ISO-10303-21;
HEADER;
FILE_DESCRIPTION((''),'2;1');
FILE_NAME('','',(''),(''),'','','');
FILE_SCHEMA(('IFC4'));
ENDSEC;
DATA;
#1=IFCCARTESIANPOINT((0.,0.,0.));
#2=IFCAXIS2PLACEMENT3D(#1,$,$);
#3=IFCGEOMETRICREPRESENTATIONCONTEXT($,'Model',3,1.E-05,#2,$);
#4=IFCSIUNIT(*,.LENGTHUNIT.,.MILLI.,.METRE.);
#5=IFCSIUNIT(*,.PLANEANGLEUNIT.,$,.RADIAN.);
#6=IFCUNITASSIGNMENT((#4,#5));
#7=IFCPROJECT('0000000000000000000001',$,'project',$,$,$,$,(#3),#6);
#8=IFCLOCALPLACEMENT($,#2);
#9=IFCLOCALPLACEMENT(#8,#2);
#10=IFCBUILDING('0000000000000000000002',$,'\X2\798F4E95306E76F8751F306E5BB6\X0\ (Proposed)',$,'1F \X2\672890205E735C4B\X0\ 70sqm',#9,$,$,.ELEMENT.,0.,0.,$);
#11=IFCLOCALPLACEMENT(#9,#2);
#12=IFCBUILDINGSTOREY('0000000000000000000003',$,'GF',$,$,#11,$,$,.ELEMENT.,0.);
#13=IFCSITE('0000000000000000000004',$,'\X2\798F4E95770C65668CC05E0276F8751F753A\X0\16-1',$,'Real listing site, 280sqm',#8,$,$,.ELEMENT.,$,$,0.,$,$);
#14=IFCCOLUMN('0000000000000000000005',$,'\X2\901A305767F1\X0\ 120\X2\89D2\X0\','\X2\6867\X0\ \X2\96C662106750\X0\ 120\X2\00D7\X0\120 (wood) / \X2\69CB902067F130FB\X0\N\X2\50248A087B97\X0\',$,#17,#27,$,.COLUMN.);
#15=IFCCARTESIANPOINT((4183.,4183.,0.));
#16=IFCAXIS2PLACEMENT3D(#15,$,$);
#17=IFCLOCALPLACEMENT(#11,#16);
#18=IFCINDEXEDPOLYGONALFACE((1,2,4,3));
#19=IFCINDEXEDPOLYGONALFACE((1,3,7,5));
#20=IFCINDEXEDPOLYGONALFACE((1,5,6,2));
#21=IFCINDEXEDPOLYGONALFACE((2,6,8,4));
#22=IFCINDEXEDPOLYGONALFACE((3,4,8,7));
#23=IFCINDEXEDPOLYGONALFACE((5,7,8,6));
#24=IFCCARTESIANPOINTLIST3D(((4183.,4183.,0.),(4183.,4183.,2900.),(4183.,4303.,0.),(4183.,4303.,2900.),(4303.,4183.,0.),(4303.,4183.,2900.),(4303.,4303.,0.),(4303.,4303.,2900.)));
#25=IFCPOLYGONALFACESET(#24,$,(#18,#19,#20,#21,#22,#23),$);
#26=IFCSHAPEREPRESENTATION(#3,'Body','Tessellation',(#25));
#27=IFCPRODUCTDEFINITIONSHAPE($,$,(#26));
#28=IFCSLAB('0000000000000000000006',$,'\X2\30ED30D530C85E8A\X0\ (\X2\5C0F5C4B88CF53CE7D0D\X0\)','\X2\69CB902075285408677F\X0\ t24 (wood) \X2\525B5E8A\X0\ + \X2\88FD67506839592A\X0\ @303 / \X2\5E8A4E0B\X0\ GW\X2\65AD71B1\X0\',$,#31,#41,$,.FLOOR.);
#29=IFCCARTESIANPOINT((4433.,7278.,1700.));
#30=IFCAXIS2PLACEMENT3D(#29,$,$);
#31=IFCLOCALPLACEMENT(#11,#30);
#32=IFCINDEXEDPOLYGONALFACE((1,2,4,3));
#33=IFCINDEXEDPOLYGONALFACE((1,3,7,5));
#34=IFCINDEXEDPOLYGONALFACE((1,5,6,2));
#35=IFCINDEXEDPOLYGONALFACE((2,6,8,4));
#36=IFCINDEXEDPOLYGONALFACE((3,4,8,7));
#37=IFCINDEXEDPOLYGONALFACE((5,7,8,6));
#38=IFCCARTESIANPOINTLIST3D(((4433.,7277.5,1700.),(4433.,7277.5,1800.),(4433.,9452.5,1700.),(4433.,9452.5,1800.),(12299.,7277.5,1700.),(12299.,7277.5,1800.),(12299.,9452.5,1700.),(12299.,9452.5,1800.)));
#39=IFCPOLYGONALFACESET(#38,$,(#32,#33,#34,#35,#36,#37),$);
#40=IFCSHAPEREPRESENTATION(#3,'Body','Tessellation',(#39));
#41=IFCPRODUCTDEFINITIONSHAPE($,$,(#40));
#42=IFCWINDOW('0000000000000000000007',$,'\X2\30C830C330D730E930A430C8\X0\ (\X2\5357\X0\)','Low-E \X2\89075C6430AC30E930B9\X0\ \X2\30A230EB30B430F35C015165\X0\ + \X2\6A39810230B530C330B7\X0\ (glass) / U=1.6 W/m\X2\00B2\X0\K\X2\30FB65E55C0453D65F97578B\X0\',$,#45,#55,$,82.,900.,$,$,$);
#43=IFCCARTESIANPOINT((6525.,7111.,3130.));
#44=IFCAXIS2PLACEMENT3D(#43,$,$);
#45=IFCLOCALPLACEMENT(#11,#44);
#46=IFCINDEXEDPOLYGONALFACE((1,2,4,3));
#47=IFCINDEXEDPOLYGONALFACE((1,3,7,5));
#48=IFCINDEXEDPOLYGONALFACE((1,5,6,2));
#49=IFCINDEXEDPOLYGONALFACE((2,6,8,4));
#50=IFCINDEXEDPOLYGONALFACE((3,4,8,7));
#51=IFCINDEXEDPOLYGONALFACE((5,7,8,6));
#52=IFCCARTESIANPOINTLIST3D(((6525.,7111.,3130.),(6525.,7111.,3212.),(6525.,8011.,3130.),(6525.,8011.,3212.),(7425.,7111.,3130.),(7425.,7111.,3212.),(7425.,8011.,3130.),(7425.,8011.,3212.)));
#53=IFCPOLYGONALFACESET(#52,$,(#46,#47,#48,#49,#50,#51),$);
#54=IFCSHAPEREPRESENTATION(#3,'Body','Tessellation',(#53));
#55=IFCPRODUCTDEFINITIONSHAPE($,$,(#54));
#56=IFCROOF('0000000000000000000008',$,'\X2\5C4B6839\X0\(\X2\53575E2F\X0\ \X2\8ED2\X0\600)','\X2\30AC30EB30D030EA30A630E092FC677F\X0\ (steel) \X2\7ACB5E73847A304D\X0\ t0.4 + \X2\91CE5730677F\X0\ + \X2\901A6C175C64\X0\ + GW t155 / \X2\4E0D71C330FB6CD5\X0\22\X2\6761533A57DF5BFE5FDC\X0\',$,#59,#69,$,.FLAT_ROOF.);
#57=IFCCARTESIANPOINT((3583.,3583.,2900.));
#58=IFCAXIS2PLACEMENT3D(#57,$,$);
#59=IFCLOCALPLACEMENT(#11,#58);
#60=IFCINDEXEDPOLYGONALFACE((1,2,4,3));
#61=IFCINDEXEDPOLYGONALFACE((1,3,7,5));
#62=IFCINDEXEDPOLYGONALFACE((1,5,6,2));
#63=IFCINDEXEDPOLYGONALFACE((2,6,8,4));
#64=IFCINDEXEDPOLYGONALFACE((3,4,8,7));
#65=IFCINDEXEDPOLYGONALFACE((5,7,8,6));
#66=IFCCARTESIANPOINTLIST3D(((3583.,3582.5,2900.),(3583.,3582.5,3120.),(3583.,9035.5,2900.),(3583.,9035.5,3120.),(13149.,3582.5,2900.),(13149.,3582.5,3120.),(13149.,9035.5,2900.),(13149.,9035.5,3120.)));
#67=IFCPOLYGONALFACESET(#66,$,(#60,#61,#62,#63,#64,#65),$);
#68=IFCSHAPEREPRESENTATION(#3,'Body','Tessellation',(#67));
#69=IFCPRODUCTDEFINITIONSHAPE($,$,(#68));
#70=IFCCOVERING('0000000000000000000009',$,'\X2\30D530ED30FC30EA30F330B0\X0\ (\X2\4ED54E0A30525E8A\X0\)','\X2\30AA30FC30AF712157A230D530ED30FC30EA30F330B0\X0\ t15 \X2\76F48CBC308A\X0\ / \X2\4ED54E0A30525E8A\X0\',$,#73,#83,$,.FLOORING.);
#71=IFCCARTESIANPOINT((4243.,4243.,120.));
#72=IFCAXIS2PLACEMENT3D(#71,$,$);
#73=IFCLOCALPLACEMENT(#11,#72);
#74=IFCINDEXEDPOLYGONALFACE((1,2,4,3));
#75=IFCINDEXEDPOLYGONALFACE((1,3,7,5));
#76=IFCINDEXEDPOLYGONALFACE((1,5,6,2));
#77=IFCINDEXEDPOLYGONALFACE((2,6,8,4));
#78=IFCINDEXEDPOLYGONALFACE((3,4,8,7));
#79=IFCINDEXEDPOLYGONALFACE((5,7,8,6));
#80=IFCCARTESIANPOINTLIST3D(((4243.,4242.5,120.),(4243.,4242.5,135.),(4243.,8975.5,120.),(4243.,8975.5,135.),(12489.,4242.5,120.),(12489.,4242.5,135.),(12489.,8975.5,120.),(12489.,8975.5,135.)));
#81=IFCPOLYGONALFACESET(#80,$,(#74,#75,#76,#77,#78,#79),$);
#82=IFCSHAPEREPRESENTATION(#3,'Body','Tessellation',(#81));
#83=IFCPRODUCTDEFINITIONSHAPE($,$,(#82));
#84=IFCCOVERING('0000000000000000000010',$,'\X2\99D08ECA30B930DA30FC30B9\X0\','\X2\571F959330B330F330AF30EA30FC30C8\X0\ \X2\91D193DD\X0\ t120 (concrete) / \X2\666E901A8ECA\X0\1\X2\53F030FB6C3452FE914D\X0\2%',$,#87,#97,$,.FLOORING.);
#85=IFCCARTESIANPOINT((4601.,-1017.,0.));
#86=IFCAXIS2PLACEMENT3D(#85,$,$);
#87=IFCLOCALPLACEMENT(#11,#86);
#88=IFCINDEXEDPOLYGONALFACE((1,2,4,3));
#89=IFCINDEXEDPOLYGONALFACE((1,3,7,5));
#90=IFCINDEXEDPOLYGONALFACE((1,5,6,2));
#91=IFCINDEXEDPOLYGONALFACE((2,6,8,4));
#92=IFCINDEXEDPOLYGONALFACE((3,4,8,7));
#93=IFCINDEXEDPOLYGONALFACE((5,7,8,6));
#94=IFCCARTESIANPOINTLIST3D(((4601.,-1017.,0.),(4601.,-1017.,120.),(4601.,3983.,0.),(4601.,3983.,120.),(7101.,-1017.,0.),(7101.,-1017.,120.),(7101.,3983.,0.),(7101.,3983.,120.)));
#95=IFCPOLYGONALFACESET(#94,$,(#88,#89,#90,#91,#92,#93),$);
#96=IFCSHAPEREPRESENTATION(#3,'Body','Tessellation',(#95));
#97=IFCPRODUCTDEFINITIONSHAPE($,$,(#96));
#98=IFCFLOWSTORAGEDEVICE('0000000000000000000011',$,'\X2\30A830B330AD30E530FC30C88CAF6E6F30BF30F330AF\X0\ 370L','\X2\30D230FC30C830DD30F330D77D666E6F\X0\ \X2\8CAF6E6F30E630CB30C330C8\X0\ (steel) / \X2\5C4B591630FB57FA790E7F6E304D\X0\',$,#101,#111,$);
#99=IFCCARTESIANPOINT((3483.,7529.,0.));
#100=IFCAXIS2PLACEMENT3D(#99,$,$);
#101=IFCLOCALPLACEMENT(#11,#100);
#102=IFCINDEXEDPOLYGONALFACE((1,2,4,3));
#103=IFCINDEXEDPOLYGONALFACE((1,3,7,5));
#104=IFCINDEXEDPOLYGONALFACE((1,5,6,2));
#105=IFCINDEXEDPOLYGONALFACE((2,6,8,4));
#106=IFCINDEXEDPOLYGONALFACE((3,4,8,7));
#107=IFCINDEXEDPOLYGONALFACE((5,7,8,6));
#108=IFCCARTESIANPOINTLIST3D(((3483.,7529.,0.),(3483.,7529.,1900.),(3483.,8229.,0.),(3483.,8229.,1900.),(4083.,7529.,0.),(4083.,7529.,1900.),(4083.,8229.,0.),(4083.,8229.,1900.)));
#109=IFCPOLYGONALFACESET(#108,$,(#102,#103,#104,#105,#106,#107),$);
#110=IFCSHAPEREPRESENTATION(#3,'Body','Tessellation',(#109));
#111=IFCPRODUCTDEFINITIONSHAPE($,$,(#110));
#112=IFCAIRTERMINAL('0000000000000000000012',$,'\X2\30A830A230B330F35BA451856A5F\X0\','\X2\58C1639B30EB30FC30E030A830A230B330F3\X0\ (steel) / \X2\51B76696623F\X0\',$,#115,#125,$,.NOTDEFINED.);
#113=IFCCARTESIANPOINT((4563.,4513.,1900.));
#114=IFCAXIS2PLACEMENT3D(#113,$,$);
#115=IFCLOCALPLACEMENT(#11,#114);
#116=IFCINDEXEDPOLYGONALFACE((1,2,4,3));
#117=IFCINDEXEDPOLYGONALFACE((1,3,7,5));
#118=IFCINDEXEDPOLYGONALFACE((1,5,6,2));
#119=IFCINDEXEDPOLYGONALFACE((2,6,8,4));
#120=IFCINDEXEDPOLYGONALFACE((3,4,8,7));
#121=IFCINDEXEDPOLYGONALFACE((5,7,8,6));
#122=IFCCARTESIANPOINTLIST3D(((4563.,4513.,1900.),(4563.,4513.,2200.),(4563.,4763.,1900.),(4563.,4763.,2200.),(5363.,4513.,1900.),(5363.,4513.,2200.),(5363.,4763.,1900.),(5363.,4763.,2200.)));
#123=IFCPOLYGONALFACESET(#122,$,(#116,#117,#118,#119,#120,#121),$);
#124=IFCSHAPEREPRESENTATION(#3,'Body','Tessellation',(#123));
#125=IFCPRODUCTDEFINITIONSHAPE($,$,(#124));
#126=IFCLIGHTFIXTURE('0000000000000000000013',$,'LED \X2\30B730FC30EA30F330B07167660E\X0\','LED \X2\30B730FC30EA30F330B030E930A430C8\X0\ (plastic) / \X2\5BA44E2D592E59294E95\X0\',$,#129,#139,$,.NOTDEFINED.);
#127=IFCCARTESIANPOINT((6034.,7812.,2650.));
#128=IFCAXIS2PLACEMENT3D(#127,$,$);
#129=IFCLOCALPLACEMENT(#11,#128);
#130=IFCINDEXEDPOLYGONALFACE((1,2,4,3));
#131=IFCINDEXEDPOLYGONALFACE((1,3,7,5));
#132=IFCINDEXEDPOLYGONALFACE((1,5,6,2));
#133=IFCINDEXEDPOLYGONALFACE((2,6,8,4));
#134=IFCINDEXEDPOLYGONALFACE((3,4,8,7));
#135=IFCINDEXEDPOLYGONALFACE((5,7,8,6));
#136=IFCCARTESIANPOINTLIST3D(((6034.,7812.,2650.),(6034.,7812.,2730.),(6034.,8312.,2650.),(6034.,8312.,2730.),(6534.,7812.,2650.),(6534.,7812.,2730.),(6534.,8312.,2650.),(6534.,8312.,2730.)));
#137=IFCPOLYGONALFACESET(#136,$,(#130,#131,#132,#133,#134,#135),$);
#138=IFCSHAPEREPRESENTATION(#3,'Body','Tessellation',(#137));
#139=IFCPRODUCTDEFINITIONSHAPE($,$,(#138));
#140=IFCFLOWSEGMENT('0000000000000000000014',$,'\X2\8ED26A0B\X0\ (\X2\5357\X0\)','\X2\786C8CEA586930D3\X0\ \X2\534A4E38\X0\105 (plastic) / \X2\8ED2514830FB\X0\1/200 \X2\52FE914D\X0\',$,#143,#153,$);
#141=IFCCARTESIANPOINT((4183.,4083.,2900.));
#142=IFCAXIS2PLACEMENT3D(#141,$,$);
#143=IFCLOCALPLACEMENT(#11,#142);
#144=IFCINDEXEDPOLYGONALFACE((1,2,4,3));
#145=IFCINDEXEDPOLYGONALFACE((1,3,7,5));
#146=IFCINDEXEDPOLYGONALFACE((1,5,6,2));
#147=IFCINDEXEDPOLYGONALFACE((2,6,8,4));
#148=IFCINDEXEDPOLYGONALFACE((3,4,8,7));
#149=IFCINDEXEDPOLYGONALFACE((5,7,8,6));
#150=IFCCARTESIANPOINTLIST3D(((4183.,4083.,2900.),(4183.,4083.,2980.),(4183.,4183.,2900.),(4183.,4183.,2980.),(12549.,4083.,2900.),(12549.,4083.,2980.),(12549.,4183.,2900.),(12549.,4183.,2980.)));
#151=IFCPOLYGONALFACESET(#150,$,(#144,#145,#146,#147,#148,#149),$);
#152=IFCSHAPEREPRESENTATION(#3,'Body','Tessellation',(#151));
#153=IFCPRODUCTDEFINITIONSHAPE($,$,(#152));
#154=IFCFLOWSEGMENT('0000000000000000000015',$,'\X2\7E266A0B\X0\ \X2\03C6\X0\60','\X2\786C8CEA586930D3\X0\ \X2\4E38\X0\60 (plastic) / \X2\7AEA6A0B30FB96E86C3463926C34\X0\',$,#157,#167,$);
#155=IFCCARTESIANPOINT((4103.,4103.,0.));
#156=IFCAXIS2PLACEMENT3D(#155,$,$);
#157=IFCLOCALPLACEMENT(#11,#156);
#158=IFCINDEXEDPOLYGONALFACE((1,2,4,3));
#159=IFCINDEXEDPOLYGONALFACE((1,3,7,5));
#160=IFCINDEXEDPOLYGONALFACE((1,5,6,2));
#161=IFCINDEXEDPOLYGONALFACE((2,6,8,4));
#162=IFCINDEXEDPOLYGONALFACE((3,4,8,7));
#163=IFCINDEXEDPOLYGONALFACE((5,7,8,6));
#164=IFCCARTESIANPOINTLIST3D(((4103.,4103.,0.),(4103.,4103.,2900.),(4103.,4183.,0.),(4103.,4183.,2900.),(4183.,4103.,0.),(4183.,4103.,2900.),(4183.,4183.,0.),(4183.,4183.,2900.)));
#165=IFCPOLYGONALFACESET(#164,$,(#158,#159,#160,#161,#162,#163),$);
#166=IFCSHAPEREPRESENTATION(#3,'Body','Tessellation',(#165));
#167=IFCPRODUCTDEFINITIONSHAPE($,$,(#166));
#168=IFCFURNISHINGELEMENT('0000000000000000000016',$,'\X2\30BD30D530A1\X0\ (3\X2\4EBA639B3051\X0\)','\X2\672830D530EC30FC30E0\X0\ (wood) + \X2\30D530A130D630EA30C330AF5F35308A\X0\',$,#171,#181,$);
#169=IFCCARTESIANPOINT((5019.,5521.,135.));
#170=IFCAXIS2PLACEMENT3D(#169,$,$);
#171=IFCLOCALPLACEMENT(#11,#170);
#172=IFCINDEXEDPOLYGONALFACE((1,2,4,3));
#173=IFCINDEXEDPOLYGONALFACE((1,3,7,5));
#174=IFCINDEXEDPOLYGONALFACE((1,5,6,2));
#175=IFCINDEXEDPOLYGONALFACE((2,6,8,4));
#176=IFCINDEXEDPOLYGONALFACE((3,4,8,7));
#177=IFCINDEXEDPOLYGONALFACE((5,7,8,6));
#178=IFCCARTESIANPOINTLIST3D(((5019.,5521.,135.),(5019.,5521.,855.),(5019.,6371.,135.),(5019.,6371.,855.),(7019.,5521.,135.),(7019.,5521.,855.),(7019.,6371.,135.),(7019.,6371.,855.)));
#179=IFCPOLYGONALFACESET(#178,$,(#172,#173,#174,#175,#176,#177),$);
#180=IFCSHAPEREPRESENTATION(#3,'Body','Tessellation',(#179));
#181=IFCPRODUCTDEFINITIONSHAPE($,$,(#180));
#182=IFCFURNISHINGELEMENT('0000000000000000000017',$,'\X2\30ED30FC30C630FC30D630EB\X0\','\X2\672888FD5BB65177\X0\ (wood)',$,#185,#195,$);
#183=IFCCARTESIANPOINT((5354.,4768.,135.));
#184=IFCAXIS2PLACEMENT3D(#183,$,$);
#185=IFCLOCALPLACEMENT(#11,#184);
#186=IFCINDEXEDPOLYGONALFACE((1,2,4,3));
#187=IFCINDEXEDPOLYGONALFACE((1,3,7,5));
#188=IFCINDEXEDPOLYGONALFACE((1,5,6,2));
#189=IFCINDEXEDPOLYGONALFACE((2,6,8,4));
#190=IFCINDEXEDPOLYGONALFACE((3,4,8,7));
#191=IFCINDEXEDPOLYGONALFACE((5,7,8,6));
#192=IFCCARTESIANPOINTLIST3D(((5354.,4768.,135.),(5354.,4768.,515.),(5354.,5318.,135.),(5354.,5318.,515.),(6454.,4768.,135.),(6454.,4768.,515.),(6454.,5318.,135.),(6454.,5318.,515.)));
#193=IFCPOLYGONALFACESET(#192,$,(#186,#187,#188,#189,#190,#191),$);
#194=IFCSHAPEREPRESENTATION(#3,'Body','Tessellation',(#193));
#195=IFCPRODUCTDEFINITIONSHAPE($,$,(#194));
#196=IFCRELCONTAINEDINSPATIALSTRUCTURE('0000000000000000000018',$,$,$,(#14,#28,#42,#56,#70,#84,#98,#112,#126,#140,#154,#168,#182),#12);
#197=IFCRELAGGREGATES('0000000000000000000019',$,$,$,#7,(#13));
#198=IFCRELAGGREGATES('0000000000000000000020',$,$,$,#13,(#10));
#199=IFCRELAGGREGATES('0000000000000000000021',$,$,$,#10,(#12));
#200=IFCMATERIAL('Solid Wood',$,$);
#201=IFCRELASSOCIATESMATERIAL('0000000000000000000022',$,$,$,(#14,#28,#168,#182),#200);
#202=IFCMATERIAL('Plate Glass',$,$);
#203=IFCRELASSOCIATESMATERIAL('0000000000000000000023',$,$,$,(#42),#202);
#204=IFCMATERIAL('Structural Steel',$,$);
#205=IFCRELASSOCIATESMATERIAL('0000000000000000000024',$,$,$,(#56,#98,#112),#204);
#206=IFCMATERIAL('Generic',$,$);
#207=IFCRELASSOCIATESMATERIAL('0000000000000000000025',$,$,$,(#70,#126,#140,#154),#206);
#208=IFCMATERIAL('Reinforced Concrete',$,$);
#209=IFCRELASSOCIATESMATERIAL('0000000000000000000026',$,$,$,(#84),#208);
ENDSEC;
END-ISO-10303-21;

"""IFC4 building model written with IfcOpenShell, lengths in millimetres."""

from ifc_helpers import new_model, si_unit, frame, frame_2d, origin, place, context, project, spatial, rectangle, extrude, material, element, save


model = new_model("IFC4")

# Units and contexts
model_context = context("Model", 3, precision=1e-05, world=origin())
ifc_project = project(units=[si_unit("LENGTHUNIT", "METRE", prefix="MILLI"), si_unit("PLANEANGLEUNIT", "RADIAN")], contexts=[model_context])

# Site, building, storey
site_placement = place(None, origin())
site = spatial("IfcSite", under=ifc_project, at=site_placement, Name="福井県敦賀市相生町16-1", ObjectType="Real listing site, 280sqm", CompositionType="ELEMENT", RefElevation=0.0)
building_placement = place(site_placement, origin())
building = spatial("IfcBuilding", under=site, at=building_placement, Name="福井の相生の家 (Proposed)", ObjectType="1F 木造平屋 70sqm", CompositionType="ELEMENT", ElevationOfRefHeight=0.0, ElevationOfTerrain=0.0)
storey_placement = place(building_placement, origin())
storey = spatial("IfcBuildingStorey", under=building, at=storey_placement, Name="GF", CompositionType="ELEMENT", Elevation=0.0)

# Column
ifc_material_1 = material(Name="Solid Wood")
column_1_placement = place(storey_placement, frame((4183.0, 4183.0, 0.0)))
element("IfcColumn", 1, at=column_1_placement, inside=storey, material=ifc_material_1, Name="通し柱 120角", Description="桧 集成材 120×120 (wood) / 構造柱・N値計算", PredefinedType="COLUMN", context=model_context, shape_type="SweptSolid", body=[
    extrude(rectangle(XDim=120.0, YDim=120.0, at=frame_2d((60.0, 60.0))), frame((4183.0, 4183.0, 0.0)), (0.0, 0.0, 1.0), 2900.0),
])

# Slab
ifc_material_2 = material(Name="Reinforced Concrete")
slab_1_placement = place(storey_placement, frame((4433.0, 7278.0, 1700.0)))
element("IfcSlab", 2, at=slab_1_placement, inside=storey, material=ifc_material_1, Name="ロフト床 (小屋裏収納)", Description="構造用合板 t24 (wood) 剛床 + 製材根太 @303 / 床下 GW断熱", PredefinedType="FLOOR", context=model_context, shape_type="SweptSolid", body=[
    extrude(rectangle(XDim=7866.0, YDim=2175.0, at=frame_2d((3933.0, 1087.0))), frame((4433.0, 7278.0, 1700.0)), (0.0, 0.0, 1.0), 100.0),
])

# Shared definitions
ifc_material_3 = material(Name="Plate Glass")

# Window
window_1_placement = place(storey_placement, frame((6525.0, 7111.0, 3130.0)))
element("IfcWindow", 3, at=window_1_placement, inside=storey, material=ifc_material_3, Name="トップライト (南)", Description="Low-E 複層ガラス アルゴン封入 + 樹脂サッシ (glass) / U=1.6 W/m²K・日射取得型", OverallHeight=82.0, OverallWidth=900.0, context=model_context, shape_type="SweptSolid", body=[
    extrude(rectangle(XDim=900.0, YDim=900.0, at=frame_2d((450.0, 450.0))), frame((6525.0, 7111.0, 3130.0)), (0.0, 0.0, 1.0), 82.0),
])

# Roof
ifc_material_4 = material(Name="Structural Steel")
roof_placement = place(storey_placement, frame((3583.0, 3583.0, 2900.0)))
element("IfcRoof", 4, at=roof_placement, inside=storey, material=ifc_material_4, Name="屋根(南帯 軒600)", Description="ガルバリウム鋼板 (steel) 立平葺き t0.4 + 野地板 + 通気層 + GW t155 / 不燃・法22条区域対応", PredefinedType="FLAT_ROOF", context=model_context, shape_type="SweptSolid", body=[
    extrude(rectangle(XDim=9566.0, YDim=5453.0, at=frame_2d((4783.0, 2726.0))), frame((3583.0, 3583.0, 2900.0)), (0.0, 0.0, 1.0), 220.0),
])

# Coverings
ifc_material_5 = material(Name="Generic")
covering_1_placement = place(storey_placement, frame((4243.0, 4243.0, 120.0)))
element("IfcCovering", 5, at=covering_1_placement, inside=storey, material=ifc_material_5, Name="フローリング (仕上げ床)", Description="オーク無垢フローリング t15 直貼り / 仕上げ床", PredefinedType="FLOORING", context=model_context, shape_type="SweptSolid", body=[
    extrude(rectangle(XDim=8246.0, YDim=4733.0, at=frame_2d((4123.0, 2366.0))), frame((4243.0, 4243.0, 120.0)), (0.0, 0.0, 1.0), 15.0),
])
covering_2_placement = place(storey_placement, frame((4601.0, -1017.0, 0.0)))
element("IfcCovering", 6, at=covering_2_placement, inside=storey, material=ifc_material_2, Name="駐車スペース", Description="土間コンクリート 金鏝 t120 (concrete) / 普通車1台・水勾配2%", PredefinedType="FLOORING", context=model_context, shape_type="SweptSolid", body=[
    extrude(rectangle(XDim=2500.0, YDim=5000.0, at=frame_2d((1250.0, 2500.0))), frame((4601.0, -1017.0, 0.0)), (0.0, 0.0, 1.0), 120.0),
])

# Flow storage device
flow_storage_device_placement = place(storey_placement, frame((3483.0, 7529.0, 0.0)))
element("IfcFlowStorageDevice", 7, at=flow_storage_device_placement, inside=storey, material=ifc_material_4, Name="エコキュート貯湯タンク 370L", Description="ヒートポンプ給湯 貯湯ユニット (steel) / 屋外・基礎置き", context=model_context, shape_type="SweptSolid", body=[
    extrude(rectangle(XDim=600.0, YDim=700.0, at=frame_2d((300.0, 350.0))), frame((3483.0, 7529.0, 0.0)), (0.0, 0.0, 1.0), 1900.0),
])

# Air terminal
air_terminal_placement = place(storey_placement, frame((4563.0, 4513.0, 1900.0)))
element("IfcAirTerminal", 8, at=air_terminal_placement, inside=storey, material=ifc_material_4, Name="エアコン室内機", Description="壁掛ルームエアコン (steel) / 冷暖房", PredefinedType="NOTDEFINED", context=model_context, shape_type="SweptSolid", body=[
    extrude(rectangle(XDim=800.0, YDim=250.0, at=frame_2d((400.0, 125.0))), frame((4563.0, 4513.0, 1900.0)), (0.0, 0.0, 1.0), 300.0),
])

# Light fixture
light_fixture_placement = place(storey_placement, frame((6034.0, 7812.0, 2650.0)))
element("IfcLightFixture", 9, at=light_fixture_placement, inside=storey, material=ifc_material_5, Name="LED シーリング照明", Description="LED シーリングライト (plastic) / 室中央天井", PredefinedType="NOTDEFINED", context=model_context, shape_type="SweptSolid", body=[
    extrude(rectangle(XDim=500.0, YDim=500.0, at=frame_2d((250.0, 250.0))), frame((6034.0, 7812.0, 2650.0)), (0.0, 0.0, 1.0), 80.0),
])

# Flow segments
flow_segment_1_placement = place(storey_placement, frame((4183.0, 4083.0, 2900.0)))
element("IfcFlowSegment", 10, at=flow_segment_1_placement, inside=storey, material=ifc_material_5, Name="軒樋 (南)", Description="硬質塩ビ 半丸105 (plastic) / 軒先・1/200 勾配", context=model_context, shape_type="SweptSolid", body=[
    extrude(rectangle(XDim=8366.0, YDim=100.0, at=frame_2d((4183.0, 50.0))), frame((4183.0, 4083.0, 2900.0)), (0.0, 0.0, 1.0), 80.0),
])
flow_segment_2_placement = place(storey_placement, frame((4103.0, 4103.0, 0.0)))
element("IfcFlowSegment", 11, at=flow_segment_2_placement, inside=storey, material=ifc_material_5, Name="縦樋 φ60", Description="硬質塩ビ 丸60 (plastic) / 竪樋・雨水排水", context=model_context, shape_type="SweptSolid", body=[
    extrude(rectangle(XDim=80.0, YDim=80.0, at=frame_2d((40.0, 40.0))), frame((4103.0, 4103.0, 0.0)), (0.0, 0.0, 1.0), 2900.0),
])

# Furnishing elements
furnishing_1_placement = place(storey_placement, frame((5019.0, 5521.0, 135.0)))
element("IfcFurnishingElement", 12, at=furnishing_1_placement, inside=storey, material=ifc_material_1, Name="ソファ (3人掛け)", Description="木フレーム (wood) + ファブリック張り", context=model_context, shape_type="SweptSolid", body=[
    extrude(rectangle(XDim=2000.0, YDim=850.0, at=frame_2d((1000.0, 425.0))), frame((5019.0, 5521.0, 135.0)), (0.0, 0.0, 1.0), 720.0),
])
furnishing_2_placement = place(storey_placement, frame((5354.0, 4768.0, 135.0)))
element("IfcFurnishingElement", 13, at=furnishing_2_placement, inside=storey, material=ifc_material_1, Name="ローテーブル", Description="木製家具 (wood)", context=model_context, shape_type="SweptSolid", body=[
    extrude(rectangle(XDim=1100.0, YDim=550.0, at=frame_2d((550.0, 275.0))), frame((5354.0, 4768.0, 135.0)), (0.0, 0.0, 1.0), 380.0),
])

save(model, "model.ifc")
